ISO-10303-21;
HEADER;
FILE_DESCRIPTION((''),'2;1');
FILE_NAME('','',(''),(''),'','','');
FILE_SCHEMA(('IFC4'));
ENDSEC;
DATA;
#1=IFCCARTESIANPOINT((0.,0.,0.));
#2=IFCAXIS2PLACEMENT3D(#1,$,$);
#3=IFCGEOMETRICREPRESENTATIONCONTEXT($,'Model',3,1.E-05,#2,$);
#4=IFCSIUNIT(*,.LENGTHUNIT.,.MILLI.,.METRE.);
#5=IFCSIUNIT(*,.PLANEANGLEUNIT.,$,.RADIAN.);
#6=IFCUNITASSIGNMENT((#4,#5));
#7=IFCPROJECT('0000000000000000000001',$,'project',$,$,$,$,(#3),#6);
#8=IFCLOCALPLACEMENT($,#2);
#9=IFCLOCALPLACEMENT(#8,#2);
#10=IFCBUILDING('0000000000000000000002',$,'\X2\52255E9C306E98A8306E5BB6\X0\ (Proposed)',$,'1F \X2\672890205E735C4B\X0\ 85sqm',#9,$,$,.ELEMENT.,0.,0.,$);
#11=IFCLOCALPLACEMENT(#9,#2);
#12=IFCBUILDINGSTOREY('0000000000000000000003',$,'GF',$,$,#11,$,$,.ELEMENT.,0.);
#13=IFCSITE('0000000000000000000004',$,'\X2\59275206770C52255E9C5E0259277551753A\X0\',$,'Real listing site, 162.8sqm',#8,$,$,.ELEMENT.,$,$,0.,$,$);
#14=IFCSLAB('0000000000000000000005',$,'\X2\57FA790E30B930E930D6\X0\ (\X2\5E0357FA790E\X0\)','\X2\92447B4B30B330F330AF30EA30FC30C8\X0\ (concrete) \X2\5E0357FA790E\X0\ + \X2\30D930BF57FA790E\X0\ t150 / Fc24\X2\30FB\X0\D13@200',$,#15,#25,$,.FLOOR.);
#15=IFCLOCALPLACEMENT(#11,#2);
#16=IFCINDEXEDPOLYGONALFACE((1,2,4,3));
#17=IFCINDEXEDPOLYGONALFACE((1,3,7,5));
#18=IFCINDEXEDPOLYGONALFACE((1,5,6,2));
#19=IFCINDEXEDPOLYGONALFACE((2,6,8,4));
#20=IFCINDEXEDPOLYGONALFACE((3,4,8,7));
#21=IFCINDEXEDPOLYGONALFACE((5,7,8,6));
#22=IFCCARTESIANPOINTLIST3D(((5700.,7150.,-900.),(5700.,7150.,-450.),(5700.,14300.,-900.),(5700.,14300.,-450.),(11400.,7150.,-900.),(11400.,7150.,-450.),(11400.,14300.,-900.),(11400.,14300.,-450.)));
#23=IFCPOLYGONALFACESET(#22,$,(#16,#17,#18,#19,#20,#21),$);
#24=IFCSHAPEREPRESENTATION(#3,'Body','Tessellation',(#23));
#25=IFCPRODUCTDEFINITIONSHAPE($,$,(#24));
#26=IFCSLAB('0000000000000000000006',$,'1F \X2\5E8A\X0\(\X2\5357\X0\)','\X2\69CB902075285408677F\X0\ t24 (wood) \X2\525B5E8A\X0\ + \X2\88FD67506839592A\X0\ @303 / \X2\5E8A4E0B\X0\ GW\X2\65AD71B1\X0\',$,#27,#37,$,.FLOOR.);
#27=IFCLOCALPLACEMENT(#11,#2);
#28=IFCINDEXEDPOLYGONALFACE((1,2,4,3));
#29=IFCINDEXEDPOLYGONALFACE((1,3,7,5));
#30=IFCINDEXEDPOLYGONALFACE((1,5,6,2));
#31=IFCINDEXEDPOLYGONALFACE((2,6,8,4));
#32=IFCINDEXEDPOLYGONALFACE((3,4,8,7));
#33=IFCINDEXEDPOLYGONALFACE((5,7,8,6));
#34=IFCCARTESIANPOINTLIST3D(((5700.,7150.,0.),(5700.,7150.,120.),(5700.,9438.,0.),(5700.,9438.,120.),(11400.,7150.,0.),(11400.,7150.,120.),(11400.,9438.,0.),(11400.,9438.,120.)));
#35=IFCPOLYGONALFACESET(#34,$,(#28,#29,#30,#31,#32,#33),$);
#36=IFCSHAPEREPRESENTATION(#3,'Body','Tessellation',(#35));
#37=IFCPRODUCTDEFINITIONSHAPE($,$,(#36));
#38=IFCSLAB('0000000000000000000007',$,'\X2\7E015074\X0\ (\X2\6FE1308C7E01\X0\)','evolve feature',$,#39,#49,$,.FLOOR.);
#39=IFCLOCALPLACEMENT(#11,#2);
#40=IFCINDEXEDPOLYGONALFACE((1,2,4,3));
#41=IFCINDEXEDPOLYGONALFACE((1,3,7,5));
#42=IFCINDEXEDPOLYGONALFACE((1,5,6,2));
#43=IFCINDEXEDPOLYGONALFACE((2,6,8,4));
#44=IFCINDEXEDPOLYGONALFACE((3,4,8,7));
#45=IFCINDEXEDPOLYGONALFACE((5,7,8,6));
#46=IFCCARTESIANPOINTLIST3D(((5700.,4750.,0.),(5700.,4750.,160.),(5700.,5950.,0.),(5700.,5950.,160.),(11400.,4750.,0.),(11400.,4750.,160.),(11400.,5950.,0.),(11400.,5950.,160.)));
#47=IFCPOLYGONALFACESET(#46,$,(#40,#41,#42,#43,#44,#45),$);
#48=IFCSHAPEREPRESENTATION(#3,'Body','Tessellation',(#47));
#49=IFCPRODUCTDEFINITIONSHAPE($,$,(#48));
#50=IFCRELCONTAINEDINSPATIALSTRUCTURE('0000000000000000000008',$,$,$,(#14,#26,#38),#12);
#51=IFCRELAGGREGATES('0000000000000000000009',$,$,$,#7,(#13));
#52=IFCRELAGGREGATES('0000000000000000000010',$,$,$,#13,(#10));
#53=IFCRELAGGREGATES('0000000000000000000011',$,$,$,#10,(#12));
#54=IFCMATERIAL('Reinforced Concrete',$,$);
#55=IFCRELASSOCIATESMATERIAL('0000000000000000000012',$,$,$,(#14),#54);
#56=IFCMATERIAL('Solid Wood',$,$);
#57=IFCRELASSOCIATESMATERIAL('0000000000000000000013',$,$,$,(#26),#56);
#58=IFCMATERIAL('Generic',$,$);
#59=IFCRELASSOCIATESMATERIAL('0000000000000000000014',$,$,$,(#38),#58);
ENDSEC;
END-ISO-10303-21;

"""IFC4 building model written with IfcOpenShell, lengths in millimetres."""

from ifc_helpers import new_model, si_unit, frame, frame_2d, origin, place, context, project, spatial, rectangle, extrude, material, element, save


model = new_model("IFC4")

# Units and contexts
model_context = context("Model", 3, precision=1e-05, world=origin())
ifc_project = project(units=[si_unit("LENGTHUNIT", "METRE", prefix="MILLI"), si_unit("PLANEANGLEUNIT", "RADIAN")], contexts=[model_context])

# Site, building, storey
site_placement = place(None, origin())
site = spatial("IfcSite", under=ifc_project, at=site_placement, Name="大分県別府市大畑町", ObjectType="Real listing site, 162.8sqm", CompositionType="ELEMENT", RefElevation=0.0)
building_placement = place(site_placement, origin())
building = spatial("IfcBuilding", under=site, at=building_placement, Name="別府の風の家 (Proposed)", ObjectType="1F 木造平屋 85sqm", CompositionType="ELEMENT", ElevationOfRefHeight=0.0, ElevationOfTerrain=0.0)
storey_placement = place(building_placement, origin())
storey = spatial("IfcBuildingStorey", under=building, at=storey_placement, Name="GF", CompositionType="ELEMENT", Elevation=0.0)

# Slabs
ifc_material_1 = material(Name="Reinforced Concrete")
slab_1_placement = place(storey_placement, frame((2850.0, 3575.0, -450.0)))
element("IfcSlab", 1, at=slab_1_placement, inside=storey, material=ifc_material_1, Name="基礎スラブ (布基礎)", Description="鉄筋コンクリート (concrete) 布基礎 + ベタ基礎 t150 / Fc24・D13@200", PredefinedType="FLOOR", context=model_context, shape_type="SweptSolid", body=[
    extrude(rectangle(XDim=5700.0, YDim=7150.0, at=frame_2d((2850.0, 3575.0))), frame((2850.0, 3575.0, -450.0)), (0.0, 0.0, 1.0), 450.0),
])
ifc_material_2 = material(Name="Solid Wood")
slab_2_placement = place(storey_placement, frame((2850.0, 3575.0, 0.0)))
element("IfcSlab", 2, at=slab_2_placement, inside=storey, material=ifc_material_2, Name="1F 床(南)", Description="構造用合板 t24 (wood) 剛床 + 製材根太 @303 / 床下 GW断熱", PredefinedType="FLOOR", context=model_context, shape_type="SweptSolid", body=[
    extrude(rectangle(XDim=5700.0, YDim=2288.0, at=frame_2d((2850.0, 1144.0))), frame((2850.0, 3575.0, 0.0)), (0.0, 0.0, 1.0), 120.0),
])
ifc_material_3 = material(Name="Generic")
slab_3_placement = place(storey_placement, frame((2850.0, 2375.0, 0.0)))
element("IfcSlab", 3, at=slab_3_placement, inside=storey, material=ifc_material_3, Name="縁側 (濡れ縁)", Description="evolve feature", PredefinedType="FLOOR", context=model_context, shape_type="SweptSolid", body=[
    extrude(rectangle(XDim=5700.0, YDim=1200.0, at=frame_2d((2850.0, 600.0))), frame((2850.0, 2375.0, 0.0)), (0.0, 0.0, 1.0), 160.0),
])

save(model, "model.ifc")
